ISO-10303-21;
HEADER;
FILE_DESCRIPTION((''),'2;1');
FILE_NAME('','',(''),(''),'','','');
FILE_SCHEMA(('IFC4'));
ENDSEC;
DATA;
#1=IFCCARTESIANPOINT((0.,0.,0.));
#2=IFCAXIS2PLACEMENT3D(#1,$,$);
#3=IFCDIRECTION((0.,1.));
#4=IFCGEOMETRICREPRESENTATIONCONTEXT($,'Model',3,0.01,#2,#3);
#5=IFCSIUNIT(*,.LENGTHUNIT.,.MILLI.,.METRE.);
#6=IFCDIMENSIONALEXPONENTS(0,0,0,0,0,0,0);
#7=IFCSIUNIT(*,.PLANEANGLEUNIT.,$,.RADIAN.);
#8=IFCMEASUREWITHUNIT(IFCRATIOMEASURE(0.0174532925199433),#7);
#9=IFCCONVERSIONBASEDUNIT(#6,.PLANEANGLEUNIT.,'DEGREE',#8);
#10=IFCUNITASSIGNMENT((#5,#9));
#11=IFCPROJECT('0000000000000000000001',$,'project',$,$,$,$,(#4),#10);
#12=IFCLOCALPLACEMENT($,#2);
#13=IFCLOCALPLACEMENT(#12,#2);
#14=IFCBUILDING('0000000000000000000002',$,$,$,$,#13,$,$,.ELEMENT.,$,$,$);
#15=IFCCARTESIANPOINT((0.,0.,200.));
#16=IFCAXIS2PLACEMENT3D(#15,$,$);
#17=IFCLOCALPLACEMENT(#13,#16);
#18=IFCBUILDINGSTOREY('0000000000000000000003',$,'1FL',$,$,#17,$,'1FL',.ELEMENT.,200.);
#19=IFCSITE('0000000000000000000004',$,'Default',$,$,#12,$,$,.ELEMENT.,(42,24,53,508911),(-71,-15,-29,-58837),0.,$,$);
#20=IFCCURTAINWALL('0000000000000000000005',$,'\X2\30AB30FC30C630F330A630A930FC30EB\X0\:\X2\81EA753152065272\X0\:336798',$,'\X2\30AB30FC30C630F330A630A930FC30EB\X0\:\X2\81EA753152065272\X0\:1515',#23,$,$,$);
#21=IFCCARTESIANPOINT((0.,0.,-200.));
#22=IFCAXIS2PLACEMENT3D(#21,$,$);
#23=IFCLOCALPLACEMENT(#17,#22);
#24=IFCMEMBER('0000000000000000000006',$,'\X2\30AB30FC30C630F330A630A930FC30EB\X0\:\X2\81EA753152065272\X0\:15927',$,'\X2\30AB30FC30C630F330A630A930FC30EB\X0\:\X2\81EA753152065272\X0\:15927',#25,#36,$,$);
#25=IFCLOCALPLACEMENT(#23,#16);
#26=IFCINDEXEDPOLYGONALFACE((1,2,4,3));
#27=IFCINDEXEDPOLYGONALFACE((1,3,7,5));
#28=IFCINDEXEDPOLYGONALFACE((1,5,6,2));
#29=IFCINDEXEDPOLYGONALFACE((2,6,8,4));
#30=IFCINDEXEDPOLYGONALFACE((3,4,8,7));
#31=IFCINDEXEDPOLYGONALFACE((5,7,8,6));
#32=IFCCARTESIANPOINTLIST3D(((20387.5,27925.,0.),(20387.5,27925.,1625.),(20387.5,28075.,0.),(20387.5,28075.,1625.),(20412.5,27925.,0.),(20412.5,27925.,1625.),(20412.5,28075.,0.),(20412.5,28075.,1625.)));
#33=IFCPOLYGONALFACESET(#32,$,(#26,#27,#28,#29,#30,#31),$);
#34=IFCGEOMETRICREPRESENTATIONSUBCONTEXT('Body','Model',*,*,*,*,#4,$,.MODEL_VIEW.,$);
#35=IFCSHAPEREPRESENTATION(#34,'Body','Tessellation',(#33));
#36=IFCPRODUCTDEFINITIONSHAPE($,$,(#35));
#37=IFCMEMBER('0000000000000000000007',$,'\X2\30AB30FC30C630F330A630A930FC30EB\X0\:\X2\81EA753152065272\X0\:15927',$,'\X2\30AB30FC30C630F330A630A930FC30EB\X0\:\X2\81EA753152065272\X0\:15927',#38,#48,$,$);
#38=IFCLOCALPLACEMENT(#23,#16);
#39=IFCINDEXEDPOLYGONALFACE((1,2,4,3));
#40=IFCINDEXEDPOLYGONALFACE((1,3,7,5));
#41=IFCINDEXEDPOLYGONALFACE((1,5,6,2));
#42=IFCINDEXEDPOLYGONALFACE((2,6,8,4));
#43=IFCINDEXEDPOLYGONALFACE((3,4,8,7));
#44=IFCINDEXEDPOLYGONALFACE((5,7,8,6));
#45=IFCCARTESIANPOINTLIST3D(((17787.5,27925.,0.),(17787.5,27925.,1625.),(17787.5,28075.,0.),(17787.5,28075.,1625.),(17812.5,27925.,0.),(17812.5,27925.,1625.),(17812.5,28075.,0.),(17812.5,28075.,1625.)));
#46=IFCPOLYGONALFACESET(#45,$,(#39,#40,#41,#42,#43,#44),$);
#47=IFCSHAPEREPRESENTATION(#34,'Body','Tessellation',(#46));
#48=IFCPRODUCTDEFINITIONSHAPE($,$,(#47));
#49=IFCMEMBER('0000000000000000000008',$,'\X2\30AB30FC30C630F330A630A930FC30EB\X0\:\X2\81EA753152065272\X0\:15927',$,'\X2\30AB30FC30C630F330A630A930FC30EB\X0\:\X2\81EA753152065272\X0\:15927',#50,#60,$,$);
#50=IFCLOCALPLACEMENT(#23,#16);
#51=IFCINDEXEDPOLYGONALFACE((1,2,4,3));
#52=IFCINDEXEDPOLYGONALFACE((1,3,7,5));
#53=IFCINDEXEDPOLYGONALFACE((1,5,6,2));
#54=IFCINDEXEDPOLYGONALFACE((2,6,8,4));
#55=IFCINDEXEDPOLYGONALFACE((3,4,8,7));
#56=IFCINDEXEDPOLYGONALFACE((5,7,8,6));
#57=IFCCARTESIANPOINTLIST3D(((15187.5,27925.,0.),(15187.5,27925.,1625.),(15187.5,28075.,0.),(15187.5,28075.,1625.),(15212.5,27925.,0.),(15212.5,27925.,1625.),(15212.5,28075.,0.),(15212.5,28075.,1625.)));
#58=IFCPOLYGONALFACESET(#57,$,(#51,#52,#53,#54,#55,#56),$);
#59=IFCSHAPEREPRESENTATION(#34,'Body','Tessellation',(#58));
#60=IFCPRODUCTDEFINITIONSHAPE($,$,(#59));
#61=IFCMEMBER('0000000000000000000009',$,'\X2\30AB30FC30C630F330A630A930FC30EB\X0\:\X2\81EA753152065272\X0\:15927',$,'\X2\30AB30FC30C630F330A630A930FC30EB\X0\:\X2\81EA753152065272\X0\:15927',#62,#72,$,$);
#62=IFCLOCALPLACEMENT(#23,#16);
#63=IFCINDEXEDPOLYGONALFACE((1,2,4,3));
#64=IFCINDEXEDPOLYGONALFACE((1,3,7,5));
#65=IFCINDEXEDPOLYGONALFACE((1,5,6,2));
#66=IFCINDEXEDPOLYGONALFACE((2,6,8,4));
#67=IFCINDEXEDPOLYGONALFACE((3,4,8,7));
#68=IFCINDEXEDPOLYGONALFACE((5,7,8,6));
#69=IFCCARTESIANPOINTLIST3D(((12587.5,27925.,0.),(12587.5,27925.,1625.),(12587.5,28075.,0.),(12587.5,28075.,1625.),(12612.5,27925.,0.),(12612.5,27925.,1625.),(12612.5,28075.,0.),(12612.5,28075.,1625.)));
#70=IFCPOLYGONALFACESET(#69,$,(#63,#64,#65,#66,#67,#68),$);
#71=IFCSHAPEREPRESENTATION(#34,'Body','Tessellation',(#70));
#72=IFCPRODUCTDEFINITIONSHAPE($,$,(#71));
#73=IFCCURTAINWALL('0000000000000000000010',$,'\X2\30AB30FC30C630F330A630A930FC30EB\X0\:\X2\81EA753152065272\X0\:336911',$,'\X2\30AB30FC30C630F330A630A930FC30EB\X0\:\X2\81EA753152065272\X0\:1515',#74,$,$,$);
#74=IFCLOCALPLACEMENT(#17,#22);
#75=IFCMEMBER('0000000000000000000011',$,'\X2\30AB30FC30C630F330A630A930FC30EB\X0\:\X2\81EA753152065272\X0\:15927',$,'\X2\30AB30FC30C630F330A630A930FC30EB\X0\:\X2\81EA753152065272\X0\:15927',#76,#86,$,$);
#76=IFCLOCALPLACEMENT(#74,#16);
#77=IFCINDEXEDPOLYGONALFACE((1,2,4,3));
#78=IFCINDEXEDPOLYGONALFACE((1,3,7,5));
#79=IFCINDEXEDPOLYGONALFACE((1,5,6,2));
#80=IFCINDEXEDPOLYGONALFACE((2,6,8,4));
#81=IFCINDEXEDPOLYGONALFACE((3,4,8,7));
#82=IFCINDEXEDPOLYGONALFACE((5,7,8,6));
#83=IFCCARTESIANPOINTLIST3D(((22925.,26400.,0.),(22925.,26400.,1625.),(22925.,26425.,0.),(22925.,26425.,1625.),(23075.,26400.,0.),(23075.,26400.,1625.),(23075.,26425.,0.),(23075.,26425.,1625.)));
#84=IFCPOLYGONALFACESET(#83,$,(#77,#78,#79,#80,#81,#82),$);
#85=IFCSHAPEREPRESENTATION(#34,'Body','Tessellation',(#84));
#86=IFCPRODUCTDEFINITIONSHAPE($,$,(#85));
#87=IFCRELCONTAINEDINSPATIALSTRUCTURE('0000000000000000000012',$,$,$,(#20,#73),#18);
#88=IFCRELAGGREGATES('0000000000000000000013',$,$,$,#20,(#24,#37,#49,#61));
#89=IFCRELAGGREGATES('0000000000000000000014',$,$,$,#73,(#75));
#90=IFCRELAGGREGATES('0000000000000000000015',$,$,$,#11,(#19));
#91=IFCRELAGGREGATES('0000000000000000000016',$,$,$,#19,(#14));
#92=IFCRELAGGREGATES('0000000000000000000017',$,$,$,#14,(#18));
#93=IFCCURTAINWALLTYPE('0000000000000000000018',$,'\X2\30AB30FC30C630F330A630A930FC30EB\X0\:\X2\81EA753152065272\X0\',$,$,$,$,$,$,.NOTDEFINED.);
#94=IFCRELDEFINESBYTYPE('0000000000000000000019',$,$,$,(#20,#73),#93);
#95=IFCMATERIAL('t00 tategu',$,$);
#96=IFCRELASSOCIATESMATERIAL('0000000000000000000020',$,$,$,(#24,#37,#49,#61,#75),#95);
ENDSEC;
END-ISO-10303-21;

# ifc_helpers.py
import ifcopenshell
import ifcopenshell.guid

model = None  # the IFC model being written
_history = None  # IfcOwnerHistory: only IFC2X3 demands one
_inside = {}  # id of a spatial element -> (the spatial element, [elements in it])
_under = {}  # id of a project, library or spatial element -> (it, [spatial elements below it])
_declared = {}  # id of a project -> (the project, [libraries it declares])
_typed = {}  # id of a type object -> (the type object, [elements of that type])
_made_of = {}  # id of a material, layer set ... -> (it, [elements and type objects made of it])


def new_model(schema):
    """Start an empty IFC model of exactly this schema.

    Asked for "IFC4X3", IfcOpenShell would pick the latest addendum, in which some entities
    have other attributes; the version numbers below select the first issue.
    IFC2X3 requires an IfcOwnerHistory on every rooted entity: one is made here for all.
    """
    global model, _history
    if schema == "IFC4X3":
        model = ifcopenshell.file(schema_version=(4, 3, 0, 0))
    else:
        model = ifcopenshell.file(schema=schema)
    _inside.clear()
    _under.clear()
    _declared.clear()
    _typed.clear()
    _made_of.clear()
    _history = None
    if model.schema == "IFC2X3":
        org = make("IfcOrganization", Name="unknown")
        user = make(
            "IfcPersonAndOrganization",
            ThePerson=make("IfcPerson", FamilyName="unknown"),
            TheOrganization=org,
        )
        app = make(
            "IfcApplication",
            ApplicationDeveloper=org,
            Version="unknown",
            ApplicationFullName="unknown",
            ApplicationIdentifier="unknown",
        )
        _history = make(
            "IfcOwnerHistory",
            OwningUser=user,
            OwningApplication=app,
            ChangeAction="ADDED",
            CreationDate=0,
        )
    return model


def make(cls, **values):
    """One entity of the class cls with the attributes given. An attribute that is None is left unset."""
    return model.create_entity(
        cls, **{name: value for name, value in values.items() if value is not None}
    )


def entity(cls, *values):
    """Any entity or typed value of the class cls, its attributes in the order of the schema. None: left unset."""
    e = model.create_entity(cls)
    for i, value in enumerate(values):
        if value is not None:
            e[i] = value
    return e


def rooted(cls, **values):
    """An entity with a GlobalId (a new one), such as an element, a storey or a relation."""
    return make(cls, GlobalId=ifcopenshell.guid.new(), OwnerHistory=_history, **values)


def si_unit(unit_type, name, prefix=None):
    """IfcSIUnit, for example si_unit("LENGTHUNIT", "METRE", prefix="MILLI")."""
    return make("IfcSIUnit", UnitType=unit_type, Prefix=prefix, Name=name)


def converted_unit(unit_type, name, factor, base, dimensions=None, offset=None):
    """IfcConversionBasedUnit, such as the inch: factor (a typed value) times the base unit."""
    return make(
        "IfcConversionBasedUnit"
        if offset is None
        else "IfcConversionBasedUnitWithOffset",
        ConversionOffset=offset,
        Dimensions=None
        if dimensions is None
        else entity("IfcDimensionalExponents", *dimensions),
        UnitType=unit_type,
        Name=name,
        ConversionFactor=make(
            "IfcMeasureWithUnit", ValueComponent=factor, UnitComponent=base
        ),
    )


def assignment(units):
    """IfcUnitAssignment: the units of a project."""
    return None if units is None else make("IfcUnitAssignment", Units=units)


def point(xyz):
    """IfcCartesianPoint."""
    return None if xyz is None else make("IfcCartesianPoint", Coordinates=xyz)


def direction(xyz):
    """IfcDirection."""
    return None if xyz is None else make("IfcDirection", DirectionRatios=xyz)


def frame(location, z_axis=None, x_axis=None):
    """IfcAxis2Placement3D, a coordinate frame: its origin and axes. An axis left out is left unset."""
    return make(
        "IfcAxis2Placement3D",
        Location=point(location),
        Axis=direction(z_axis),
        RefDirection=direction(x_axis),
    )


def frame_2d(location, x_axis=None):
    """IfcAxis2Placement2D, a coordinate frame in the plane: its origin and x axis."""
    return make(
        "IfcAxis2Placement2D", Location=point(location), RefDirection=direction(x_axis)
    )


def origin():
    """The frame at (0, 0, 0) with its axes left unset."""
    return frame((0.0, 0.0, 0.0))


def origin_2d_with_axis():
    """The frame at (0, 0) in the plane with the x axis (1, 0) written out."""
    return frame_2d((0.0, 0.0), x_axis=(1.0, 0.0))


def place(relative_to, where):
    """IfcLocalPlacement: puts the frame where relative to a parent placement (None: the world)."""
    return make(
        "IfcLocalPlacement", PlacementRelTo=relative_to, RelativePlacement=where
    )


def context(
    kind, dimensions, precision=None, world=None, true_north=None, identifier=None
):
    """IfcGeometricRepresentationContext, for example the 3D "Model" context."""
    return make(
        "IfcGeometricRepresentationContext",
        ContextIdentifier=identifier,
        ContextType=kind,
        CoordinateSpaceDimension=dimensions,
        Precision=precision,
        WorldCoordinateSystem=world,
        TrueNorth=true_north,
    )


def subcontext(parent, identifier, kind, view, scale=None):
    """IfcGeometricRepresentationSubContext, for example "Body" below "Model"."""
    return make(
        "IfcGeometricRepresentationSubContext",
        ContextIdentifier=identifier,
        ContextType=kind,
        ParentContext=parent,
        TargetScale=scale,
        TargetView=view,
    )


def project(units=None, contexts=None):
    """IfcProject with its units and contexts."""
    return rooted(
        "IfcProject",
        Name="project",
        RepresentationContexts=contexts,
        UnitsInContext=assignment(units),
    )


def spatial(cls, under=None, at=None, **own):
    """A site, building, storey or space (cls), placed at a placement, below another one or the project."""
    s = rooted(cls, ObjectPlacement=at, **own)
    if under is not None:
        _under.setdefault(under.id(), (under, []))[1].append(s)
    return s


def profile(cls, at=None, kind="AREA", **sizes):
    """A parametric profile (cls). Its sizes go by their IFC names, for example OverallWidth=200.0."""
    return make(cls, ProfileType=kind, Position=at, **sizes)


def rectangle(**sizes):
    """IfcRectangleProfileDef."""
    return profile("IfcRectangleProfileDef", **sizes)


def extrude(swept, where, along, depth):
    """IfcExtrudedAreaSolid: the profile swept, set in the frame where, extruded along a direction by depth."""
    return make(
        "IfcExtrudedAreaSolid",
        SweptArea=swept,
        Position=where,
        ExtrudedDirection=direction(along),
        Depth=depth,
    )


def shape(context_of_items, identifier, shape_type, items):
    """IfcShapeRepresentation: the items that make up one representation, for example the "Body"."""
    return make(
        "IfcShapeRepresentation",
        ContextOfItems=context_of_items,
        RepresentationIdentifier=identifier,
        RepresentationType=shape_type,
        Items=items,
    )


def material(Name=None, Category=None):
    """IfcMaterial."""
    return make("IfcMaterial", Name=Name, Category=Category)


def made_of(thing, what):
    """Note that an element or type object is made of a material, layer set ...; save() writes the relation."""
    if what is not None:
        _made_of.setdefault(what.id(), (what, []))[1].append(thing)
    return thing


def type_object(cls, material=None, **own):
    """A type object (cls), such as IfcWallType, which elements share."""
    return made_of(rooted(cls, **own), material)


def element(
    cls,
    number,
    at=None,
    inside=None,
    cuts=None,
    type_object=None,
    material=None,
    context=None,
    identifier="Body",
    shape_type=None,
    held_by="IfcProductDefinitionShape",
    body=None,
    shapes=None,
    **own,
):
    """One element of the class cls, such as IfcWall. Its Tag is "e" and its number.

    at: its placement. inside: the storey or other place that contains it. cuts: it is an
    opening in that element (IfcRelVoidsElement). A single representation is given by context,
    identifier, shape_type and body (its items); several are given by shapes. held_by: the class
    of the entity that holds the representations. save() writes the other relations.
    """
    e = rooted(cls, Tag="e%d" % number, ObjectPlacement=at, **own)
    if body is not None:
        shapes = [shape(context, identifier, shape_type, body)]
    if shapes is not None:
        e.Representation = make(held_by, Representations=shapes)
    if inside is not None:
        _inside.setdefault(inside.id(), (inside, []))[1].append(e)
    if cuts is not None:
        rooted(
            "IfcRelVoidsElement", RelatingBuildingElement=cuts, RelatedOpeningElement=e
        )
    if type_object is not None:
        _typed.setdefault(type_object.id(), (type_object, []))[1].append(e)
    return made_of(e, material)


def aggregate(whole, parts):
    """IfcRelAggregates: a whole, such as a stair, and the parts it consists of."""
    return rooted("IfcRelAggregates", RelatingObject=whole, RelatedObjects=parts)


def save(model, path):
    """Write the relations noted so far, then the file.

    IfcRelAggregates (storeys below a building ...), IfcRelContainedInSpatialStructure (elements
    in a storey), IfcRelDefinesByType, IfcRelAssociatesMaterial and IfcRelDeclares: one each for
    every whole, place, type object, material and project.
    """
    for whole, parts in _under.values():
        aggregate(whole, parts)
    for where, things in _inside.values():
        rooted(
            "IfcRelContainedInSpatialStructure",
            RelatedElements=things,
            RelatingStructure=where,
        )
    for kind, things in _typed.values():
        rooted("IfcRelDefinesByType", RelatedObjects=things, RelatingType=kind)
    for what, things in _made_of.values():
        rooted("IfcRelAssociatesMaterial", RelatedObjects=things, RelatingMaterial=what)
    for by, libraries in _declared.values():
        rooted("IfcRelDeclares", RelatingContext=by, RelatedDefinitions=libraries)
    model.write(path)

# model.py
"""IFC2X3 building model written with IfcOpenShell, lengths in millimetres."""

from ifc_helpers import new_model, entity, si_unit, converted_unit, direction, frame, frame_2d, origin, origin_2d_with_axis, place, context, subcontext, project, spatial, rectangle, extrude, material, type_object, element, aggregate, save


model = new_model("IFC2X3")

# Units and contexts
model_context = context("Model", 3, precision=0.01, world=origin(), true_north=direction((0.0, 1.0)))
body_context = subcontext(model_context, "Body", "Model", "MODEL_VIEW")
ifc_project = project(units=[si_unit("LENGTHUNIT", "METRE", prefix="MILLI"), converted_unit("PLANEANGLEUNIT", "DEGREE", entity("IfcRatioMeasure", 0.0174532925199433), si_unit("PLANEANGLEUNIT", "RADIAN"), dimensions=[0, 0, 0, 0, 0, 0, 0])], contexts=[model_context])

# Site, building, storey
site_placement = place(None, origin())
site = spatial("IfcSite", under=ifc_project, at=site_placement, Name="Default", CompositionType="ELEMENT", RefLatitude=(42, 24, 53, 508911), RefLongitude=(-71, -15, -29, -58837), RefElevation=0.0)
building_placement = place(site_placement, origin())
building = spatial("IfcBuilding", under=site, at=building_placement, CompositionType="ELEMENT")
storey_placement = place(building_placement, frame((0.0, 0.0, 200.0)))
storey = spatial("IfcBuildingStorey", under=building, at=storey_placement, Name="1FL", LongName="1FL", CompositionType="ELEMENT", Elevation=200.0)

# Curtain walls, members
curtain_wall_type = type_object("IfcCurtainWallType", Name="カーテンウォール:自由分割", PredefinedType="NOTDEFINED")
curtain_wall_1_placement = place(storey_placement, frame((0.0, 0.0, -200.0)))
curtain_wall_1 = element("IfcCurtainWall", 1, at=curtain_wall_1_placement, inside=storey, type_object=curtain_wall_type, Name="カーテンウォール:自由分割:336798", ObjectType="カーテンウォール:自由分割:1515")
ifc_material = material(Name="t00 tategu")
member_1_placement = place(curtain_wall_1_placement, frame((0.0, 0.0, 200.0)))
member_1 = element("IfcMember", 2, at=member_1_placement, material=ifc_material, Name="カーテンウォール:自由分割:15927", ObjectType="カーテンウォール:自由分割:15927", context=body_context, shape_type="SweptSolid", body=[
    extrude(rectangle(XDim=25.0, YDim=150.0, at=origin_2d_with_axis()), frame((20400.0, 28000.0, 0.0), z_axis=(0.0, 0.0, 1.0), x_axis=(-1.0, 0.0, 0.0)), (0.0, 0.0, 1.0), 1625.0),
])
member_2_placement = place(curtain_wall_1_placement, frame((0.0, 0.0, 200.0)))
member_2 = element("IfcMember", 3, at=member_2_placement, material=ifc_material, Name="カーテンウォール:自由分割:15927", ObjectType="カーテンウォール:自由分割:15927", context=body_context, shape_type="SweptSolid", body=[
    extrude(rectangle(XDim=25.0, YDim=150.0, at=origin_2d_with_axis()), frame((17800.0, 28000.0, 0.0), z_axis=(0.0, 0.0, 1.0), x_axis=(-1.0, 0.0, 0.0)), (0.0, 0.0, 1.0), 1625.0),
])
member_3_placement = place(curtain_wall_1_placement, frame((0.0, 0.0, 200.0)))
member_3 = element("IfcMember", 4, at=member_3_placement, material=ifc_material, Name="カーテンウォール:自由分割:15927", ObjectType="カーテンウォール:自由分割:15927", context=body_context, shape_type="SweptSolid", body=[
    extrude(rectangle(XDim=25.0, YDim=150.0, at=origin_2d_with_axis()), frame((15200.0, 28000.0, 0.0), z_axis=(0.0, 0.0, 1.0), x_axis=(-1.0, 0.0, 0.0)), (0.0, 0.0, 1.0), 1625.0),
])
member_4_placement = place(curtain_wall_1_placement, frame((0.0, 0.0, 200.0)))
member_4 = element("IfcMember", 5, at=member_4_placement, material=ifc_material, Name="カーテンウォール:自由分割:15927", ObjectType="カーテンウォール:自由分割:15927", context=body_context, shape_type="SweptSolid", body=[
    extrude(rectangle(XDim=25.0, YDim=150.0, at=origin_2d_with_axis()), frame((12600.0, 28000.0, 0.0), z_axis=(0.0, 0.0, 1.0), x_axis=(-1.0, 0.0, 0.0)), (0.0, 0.0, 1.0), 1625.0),
])
aggregate(curtain_wall_1, [member_1, member_2, member_3, member_4])
curtain_wall_2_placement = place(storey_placement, frame((0.0, 0.0, -200.0)))
curtain_wall_2 = element("IfcCurtainWall", 6, at=curtain_wall_2_placement, inside=storey, type_object=curtain_wall_type, Name="カーテンウォール:自由分割:336911", ObjectType="カーテンウォール:自由分割:1515")
member_5_placement = place(curtain_wall_2_placement, frame((0.0, 0.0, 200.0)))
member_5 = element("IfcMember", 7, at=member_5_placement, material=ifc_material, Name="カーテンウォール:自由分割:15927", ObjectType="カーテンウォール:自由分割:15927", context=body_context, shape_type="SweptSolid", body=[
    extrude(rectangle(XDim=150.0, YDim=25.0, at=frame_2d((0.0, 0.0), x_axis=(1.0, 0.0))), frame((23000.0, 26412.5, 0.0), z_axis=(0.0, 0.0, 1.0), x_axis=(-1.0, 0.0, 0.0)), (0.0, 0.0, 1.0), 1625.0),
])
aggregate(curtain_wall_2, [member_5])

save(model, "model.ifc")
